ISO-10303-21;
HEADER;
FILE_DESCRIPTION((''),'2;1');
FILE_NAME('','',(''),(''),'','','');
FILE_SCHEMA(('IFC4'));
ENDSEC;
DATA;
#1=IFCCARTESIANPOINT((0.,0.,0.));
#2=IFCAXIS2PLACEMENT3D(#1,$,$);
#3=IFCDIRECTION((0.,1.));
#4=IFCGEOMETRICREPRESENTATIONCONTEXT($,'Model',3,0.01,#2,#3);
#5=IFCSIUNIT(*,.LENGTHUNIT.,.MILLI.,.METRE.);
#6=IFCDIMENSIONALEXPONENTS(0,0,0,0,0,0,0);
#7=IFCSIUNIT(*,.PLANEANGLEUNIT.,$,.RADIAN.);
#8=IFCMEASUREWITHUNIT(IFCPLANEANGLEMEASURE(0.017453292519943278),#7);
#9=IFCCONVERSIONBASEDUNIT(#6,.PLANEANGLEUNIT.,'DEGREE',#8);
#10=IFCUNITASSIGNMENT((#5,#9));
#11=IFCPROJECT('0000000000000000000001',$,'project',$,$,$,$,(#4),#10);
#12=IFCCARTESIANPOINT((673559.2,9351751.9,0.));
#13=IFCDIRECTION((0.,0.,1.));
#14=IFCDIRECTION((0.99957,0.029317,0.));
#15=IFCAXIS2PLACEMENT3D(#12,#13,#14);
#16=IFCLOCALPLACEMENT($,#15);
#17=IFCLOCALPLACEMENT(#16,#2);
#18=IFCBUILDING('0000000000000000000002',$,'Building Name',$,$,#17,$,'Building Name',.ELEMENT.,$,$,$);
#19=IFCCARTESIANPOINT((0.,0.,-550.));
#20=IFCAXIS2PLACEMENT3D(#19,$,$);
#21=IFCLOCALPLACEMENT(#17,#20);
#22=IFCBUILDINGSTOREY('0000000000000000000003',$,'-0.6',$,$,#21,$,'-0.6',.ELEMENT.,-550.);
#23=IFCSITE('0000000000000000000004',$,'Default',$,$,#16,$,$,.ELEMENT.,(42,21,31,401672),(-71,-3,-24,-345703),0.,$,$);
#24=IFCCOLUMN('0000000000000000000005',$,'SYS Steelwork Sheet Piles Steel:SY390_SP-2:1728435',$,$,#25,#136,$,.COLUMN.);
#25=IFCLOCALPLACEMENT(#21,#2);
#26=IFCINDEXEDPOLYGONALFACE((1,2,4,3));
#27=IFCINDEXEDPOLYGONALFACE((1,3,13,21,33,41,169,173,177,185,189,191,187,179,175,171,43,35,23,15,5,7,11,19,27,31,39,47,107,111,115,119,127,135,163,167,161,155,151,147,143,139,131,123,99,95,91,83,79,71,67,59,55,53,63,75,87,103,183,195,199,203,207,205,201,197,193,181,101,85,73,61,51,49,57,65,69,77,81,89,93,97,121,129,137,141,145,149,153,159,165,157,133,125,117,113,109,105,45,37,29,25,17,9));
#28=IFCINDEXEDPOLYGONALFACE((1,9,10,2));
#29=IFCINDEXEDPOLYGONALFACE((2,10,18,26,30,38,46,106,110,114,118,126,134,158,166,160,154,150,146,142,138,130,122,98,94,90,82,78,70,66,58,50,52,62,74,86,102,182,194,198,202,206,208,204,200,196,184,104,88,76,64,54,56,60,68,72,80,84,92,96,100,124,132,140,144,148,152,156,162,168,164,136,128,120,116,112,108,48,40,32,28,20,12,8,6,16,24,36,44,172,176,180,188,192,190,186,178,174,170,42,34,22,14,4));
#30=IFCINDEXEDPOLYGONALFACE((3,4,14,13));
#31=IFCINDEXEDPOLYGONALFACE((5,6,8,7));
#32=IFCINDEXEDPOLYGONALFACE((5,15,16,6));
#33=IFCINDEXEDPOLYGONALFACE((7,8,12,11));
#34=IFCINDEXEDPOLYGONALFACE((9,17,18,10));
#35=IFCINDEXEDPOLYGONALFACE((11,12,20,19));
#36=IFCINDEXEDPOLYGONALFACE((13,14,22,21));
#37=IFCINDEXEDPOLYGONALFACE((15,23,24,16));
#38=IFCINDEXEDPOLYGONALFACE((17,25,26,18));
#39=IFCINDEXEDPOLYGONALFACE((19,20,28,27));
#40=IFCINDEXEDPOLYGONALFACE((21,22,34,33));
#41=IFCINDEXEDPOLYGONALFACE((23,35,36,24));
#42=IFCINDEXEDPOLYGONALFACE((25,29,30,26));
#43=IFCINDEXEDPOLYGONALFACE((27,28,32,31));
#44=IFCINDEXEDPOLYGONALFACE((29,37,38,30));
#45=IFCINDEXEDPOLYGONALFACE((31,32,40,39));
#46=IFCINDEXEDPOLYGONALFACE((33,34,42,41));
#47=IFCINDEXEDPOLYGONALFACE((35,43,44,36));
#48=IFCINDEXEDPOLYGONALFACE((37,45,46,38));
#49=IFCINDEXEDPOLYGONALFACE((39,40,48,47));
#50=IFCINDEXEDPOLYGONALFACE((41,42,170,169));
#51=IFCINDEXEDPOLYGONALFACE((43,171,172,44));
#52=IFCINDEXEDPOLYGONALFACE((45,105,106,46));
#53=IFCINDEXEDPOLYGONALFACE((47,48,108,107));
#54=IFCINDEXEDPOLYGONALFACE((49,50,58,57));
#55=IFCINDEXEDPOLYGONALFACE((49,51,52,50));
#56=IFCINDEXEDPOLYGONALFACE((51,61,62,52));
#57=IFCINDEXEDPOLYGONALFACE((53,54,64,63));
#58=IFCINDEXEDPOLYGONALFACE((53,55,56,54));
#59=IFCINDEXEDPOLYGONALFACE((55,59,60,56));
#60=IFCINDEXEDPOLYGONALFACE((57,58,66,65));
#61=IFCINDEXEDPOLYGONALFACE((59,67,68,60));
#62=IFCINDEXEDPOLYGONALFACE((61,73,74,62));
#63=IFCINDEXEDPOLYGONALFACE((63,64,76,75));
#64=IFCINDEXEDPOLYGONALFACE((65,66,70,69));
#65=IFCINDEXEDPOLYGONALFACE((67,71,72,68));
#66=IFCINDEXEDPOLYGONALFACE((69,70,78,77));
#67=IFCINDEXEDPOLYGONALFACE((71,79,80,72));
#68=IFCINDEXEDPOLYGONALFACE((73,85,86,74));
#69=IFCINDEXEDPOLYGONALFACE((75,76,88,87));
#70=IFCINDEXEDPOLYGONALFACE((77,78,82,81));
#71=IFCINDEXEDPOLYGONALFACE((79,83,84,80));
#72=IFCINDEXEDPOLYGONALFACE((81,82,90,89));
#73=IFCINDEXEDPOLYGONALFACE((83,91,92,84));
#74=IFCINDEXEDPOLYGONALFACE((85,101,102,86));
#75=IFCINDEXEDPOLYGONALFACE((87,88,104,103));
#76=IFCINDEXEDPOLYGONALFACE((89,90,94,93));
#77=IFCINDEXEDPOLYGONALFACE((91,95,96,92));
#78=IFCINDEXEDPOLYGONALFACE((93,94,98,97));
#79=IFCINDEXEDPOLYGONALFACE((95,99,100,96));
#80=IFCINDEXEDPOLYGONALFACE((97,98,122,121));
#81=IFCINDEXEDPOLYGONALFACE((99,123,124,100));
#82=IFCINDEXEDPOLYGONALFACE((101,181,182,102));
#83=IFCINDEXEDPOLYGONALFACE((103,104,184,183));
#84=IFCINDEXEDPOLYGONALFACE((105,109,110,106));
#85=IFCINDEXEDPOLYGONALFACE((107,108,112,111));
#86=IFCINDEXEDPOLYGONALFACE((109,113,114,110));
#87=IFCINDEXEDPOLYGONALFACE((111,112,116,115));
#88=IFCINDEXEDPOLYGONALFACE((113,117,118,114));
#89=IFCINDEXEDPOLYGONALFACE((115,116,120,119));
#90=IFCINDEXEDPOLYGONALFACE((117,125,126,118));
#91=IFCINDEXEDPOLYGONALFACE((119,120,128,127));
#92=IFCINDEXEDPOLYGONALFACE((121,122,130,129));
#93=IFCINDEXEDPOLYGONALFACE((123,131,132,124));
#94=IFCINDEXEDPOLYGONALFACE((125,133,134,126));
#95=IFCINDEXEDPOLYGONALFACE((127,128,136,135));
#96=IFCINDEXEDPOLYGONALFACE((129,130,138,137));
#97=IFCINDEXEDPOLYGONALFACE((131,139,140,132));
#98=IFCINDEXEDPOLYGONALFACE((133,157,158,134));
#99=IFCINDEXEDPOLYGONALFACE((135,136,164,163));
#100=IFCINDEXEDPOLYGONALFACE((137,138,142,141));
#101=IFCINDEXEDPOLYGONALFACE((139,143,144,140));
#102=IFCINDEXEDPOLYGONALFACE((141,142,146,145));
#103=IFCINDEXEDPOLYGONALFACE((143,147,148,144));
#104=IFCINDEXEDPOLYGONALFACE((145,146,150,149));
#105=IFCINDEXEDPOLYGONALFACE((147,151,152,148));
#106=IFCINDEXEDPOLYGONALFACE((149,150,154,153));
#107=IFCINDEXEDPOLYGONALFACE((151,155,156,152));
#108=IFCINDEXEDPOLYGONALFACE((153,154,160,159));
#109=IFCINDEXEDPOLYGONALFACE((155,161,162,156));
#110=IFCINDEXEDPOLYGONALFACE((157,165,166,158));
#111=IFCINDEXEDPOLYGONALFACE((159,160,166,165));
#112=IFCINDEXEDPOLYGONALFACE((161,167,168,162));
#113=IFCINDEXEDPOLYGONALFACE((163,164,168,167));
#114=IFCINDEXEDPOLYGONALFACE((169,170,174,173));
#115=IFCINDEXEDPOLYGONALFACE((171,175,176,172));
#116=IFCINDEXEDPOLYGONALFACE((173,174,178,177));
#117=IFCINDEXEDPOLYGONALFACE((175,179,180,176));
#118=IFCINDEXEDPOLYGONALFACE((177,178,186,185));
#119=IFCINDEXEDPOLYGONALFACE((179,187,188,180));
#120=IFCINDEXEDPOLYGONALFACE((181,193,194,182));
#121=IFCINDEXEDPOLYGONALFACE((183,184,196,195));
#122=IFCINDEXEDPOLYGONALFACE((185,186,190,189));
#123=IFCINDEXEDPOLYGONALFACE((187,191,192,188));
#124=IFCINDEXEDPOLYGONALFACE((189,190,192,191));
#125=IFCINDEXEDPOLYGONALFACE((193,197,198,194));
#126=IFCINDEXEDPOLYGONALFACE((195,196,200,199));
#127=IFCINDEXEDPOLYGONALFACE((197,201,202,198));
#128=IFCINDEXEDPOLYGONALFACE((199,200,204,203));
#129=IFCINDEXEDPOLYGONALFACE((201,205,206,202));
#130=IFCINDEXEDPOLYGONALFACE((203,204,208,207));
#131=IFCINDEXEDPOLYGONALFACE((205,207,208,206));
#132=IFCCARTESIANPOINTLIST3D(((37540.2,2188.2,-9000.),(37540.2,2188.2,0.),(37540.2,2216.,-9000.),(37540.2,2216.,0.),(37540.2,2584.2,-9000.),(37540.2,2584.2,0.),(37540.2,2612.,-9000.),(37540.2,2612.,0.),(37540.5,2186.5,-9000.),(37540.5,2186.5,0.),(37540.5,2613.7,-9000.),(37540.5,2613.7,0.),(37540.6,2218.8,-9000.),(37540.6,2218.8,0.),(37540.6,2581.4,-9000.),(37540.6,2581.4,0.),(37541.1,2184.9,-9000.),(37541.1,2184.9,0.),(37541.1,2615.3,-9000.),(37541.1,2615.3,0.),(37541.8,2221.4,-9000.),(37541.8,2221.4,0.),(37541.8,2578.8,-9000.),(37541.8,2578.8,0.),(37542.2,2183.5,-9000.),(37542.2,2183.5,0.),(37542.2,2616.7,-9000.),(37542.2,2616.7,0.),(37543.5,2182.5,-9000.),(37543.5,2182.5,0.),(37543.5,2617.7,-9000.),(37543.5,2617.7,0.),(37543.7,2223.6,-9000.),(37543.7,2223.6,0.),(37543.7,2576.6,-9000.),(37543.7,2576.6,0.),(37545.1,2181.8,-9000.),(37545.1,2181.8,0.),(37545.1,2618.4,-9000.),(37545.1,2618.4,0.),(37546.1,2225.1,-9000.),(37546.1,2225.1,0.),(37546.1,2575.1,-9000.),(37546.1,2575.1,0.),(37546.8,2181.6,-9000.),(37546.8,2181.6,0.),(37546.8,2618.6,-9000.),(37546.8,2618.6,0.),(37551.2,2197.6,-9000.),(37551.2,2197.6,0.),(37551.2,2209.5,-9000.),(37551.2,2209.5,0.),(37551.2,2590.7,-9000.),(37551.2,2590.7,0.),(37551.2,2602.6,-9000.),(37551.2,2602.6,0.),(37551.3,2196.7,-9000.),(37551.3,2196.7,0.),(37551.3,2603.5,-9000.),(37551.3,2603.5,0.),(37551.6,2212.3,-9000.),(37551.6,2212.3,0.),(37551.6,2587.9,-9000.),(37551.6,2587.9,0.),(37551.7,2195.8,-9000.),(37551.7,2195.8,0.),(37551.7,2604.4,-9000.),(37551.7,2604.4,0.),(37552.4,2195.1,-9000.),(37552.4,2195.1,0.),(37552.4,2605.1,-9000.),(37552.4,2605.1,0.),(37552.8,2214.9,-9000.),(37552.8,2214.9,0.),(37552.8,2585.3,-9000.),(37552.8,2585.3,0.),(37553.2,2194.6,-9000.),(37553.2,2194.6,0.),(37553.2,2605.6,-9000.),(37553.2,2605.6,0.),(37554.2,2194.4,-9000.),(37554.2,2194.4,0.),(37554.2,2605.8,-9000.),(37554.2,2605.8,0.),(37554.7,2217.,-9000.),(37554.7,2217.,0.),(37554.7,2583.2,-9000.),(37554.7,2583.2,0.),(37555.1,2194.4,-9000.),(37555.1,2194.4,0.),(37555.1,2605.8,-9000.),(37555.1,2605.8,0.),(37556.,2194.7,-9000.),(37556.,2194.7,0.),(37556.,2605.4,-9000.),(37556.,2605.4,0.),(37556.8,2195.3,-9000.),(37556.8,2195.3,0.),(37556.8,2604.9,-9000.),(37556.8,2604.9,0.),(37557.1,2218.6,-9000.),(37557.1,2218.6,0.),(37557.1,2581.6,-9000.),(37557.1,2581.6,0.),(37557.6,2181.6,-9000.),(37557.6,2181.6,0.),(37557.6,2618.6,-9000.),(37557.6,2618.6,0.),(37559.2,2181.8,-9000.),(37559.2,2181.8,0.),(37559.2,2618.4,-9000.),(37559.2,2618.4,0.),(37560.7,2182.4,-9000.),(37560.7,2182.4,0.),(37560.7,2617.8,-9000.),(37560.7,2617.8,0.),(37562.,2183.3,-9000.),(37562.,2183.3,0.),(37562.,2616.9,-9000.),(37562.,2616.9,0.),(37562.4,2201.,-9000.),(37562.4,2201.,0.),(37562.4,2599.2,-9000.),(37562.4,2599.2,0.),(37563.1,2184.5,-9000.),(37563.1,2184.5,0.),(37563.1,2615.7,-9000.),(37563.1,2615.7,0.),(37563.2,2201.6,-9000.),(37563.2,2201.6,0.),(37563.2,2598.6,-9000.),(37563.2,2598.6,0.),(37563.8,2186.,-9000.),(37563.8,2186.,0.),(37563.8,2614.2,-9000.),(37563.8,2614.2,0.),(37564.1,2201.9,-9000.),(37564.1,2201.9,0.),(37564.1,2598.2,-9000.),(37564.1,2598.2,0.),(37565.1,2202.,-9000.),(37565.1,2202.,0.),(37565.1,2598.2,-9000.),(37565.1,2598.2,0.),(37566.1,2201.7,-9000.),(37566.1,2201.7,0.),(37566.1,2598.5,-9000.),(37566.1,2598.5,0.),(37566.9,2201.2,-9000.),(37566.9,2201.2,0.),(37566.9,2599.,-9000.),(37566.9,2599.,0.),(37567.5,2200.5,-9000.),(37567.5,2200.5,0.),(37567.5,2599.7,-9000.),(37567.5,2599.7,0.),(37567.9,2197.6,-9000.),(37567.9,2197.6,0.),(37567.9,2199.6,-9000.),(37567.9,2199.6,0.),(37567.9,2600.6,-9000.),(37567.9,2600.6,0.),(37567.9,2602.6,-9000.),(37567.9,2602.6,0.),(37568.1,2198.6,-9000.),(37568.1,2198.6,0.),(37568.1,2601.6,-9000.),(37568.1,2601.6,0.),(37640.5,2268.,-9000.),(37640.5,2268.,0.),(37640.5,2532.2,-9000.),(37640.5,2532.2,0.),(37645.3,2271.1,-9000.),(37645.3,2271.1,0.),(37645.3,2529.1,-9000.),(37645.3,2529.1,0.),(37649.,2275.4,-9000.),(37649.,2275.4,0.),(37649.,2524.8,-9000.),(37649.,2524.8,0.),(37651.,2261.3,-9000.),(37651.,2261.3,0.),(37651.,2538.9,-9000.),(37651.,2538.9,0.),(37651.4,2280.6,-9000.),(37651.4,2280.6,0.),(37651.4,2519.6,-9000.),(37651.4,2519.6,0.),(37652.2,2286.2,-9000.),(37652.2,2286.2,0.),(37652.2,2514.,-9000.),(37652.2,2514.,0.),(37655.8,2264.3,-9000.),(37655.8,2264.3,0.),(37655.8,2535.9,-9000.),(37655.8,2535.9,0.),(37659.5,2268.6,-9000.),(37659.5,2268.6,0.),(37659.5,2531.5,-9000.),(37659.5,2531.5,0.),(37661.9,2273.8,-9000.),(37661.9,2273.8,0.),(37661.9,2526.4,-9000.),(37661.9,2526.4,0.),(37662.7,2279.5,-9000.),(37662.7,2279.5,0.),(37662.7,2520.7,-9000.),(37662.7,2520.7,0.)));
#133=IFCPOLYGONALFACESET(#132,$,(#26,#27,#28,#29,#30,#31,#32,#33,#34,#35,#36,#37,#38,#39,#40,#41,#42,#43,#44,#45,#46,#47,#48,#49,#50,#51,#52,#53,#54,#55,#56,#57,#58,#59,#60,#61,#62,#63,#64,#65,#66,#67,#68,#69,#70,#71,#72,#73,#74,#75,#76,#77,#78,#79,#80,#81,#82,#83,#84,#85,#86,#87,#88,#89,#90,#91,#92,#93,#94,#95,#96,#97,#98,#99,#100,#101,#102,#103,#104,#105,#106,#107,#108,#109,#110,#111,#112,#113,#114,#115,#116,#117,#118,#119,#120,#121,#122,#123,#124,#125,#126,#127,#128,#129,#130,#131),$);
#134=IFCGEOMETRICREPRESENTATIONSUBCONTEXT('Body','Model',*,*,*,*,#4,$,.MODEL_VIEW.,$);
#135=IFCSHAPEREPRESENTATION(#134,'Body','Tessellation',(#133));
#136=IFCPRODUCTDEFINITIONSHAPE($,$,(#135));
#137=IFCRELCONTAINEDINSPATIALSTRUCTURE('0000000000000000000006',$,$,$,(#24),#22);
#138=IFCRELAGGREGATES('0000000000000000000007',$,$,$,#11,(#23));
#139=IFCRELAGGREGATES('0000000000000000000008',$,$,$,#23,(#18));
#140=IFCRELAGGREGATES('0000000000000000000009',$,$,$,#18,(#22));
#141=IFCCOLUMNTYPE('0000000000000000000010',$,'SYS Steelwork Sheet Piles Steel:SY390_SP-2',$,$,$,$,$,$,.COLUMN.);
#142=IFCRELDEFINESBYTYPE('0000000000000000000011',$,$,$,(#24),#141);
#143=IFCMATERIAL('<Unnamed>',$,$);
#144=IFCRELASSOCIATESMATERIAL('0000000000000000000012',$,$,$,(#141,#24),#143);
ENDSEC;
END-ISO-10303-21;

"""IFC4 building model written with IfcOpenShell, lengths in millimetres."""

from ifc_helpers import new_model, entity, si_unit, converted_unit, direction, frame, origin, place, context, subcontext, project, spatial, line, arc, indexed_curve, outline, extrude, source, transform, mapped, material, type_object, type_shapes, element, save


model = new_model("IFC4")

# Units and contexts
model_context = context("Model", 3, precision=0.01, world=origin(), true_north=direction((0.0, 1.0)))
body_context = subcontext(model_context, "Body", "Model", "MODEL_VIEW")
ifc_project = project(units=[si_unit("LENGTHUNIT", "METRE", prefix="MILLI"), converted_unit("PLANEANGLEUNIT", "DEGREE", entity("IfcPlaneAngleMeasure", 0.017453292519943278), si_unit("PLANEANGLEUNIT", "RADIAN"), dimensions=[0, 0, 0, 0, 0, 0, 0])], contexts=[model_context])

# Site, building, storey
site_placement = place(None, frame((673559.2, 9351751.9, 0.0), z_axis=(0.0, 0.0, 1.0), x_axis=(0.99957, 0.029317, 0.0)))
site = spatial("IfcSite", under=ifc_project, at=site_placement, Name="Default", CompositionType="ELEMENT", RefLatitude=(42, 21, 31, 401672), RefLongitude=(-71, -3, -24, -345703), RefElevation=0.0)
building_placement = place(site_placement, origin())
building = spatial("IfcBuilding", under=site, at=building_placement, Name="Building Name", LongName="Building Name", CompositionType="ELEMENT")
storey_placement = place(building_placement, frame((0.0, 0.0, -550.0)))
storey = spatial("IfcBuildingStorey", under=building, at=storey_placement, Name="-0.6", LongName="-0.6", CompositionType="ELEMENT", Elevation=-550.0)

# Column
ifc_material_1 = material(Name="<Unnamed>")
column_type = type_object("IfcColumnType", Name="SYS Steelwork Sheet Piles Steel:SY390_SP-2", PredefinedType="COLUMN", material=ifc_material_1)
shared_shape = source(origin(), body_context, "Body", "SweptSolid", [
    extrude(outline(indexed_curve([(-120.6, 84.7), (-131.4, 81.6), (-138.8, 73.0), (-181.5, -20.9), (-185.2, -25.2), (-190.6, -26.8), (-202.5, -26.8), (-205.5, -24.8), (-204.8, -21.2), (-199.1, -15.5), (-198.6, -11.5), (-202.5, -10.1), (-214.1, -14.2), (-217.3, -16.6), (-218.5, -20.4), (-218.5, -31.2), (-216.6, -35.8), (-211.9, -37.8), (-184.1, -37.8), (-178.7, -36.2), (-175.0, -31.9), (-132.1, 62.5), (-124.7, 71.1), (-113.9, 74.2), (113.9, 74.2), (124.7, 71.1), (132.1, 62.5), (175.0, -31.9), (178.7, -36.2), (184.1, -37.8), (211.9, -37.8), (216.6, -35.8), (218.5, -31.2), (218.5, -20.4), (217.3, -16.6), (214.1, -14.2), (202.5, -10.1), (198.6, -11.5), (199.1, -15.5), (204.8, -21.2), (205.5, -24.8), (202.5, -26.8), (190.6, -26.8), (185.2, -25.2), (181.5, -20.9), (138.8, 73.0), (131.4, 81.6), (120.6, 84.7)], segments=[arc(1, 2, 3), line(3, 4), arc(4, 5, 6), line(6, 7), arc(7, 8, 9), line(9, 10), arc(10, 11, 12), line(12, 13), arc(13, 14, 15), line(15, 16), arc(16, 17, 18), line(18, 19), arc(19, 20, 21), line(21, 22), arc(22, 23, 24), line(24, 25), arc(25, 26, 27), line(27, 28), arc(28, 29, 30), line(30, 31), arc(31, 32, 33), line(33, 34), arc(34, 35, 36), line(36, 37), arc(37, 38, 39), line(39, 40), arc(40, 41, 42), line(42, 43), arc(43, 44, 45), line(45, 46), arc(46, 47, 48), line(48, 1)], self_intersect=False)), frame((0.0, 15.3, -9550.0)), (0.0, 0.0, 1.0), 9000.0),
])
type_shapes(column_type, [shared_shape])
for number, where, z_axis, x_axis, name in (
    (1, (37562.7, 2400.1, 550.0), (0.0, 0.0, 1.0), (0.0, -1.0, 0.0), "SYS Steelwork Sheet Piles Steel:SY390_SP-2:1728435"),
):
    element("IfcColumn", number, at=place(storey_placement, frame(where, z_axis=z_axis, x_axis=x_axis)), inside=storey, type_object=column_type, material=ifc_material_1, Name=name, PredefinedType="COLUMN", context=body_context, shape_type="MappedRepresentation", body=[
        mapped(shared_shape, transform((0.0, 0.0, 0.0), scale=1.0)),
    ])

save(model, "model.ifc")
